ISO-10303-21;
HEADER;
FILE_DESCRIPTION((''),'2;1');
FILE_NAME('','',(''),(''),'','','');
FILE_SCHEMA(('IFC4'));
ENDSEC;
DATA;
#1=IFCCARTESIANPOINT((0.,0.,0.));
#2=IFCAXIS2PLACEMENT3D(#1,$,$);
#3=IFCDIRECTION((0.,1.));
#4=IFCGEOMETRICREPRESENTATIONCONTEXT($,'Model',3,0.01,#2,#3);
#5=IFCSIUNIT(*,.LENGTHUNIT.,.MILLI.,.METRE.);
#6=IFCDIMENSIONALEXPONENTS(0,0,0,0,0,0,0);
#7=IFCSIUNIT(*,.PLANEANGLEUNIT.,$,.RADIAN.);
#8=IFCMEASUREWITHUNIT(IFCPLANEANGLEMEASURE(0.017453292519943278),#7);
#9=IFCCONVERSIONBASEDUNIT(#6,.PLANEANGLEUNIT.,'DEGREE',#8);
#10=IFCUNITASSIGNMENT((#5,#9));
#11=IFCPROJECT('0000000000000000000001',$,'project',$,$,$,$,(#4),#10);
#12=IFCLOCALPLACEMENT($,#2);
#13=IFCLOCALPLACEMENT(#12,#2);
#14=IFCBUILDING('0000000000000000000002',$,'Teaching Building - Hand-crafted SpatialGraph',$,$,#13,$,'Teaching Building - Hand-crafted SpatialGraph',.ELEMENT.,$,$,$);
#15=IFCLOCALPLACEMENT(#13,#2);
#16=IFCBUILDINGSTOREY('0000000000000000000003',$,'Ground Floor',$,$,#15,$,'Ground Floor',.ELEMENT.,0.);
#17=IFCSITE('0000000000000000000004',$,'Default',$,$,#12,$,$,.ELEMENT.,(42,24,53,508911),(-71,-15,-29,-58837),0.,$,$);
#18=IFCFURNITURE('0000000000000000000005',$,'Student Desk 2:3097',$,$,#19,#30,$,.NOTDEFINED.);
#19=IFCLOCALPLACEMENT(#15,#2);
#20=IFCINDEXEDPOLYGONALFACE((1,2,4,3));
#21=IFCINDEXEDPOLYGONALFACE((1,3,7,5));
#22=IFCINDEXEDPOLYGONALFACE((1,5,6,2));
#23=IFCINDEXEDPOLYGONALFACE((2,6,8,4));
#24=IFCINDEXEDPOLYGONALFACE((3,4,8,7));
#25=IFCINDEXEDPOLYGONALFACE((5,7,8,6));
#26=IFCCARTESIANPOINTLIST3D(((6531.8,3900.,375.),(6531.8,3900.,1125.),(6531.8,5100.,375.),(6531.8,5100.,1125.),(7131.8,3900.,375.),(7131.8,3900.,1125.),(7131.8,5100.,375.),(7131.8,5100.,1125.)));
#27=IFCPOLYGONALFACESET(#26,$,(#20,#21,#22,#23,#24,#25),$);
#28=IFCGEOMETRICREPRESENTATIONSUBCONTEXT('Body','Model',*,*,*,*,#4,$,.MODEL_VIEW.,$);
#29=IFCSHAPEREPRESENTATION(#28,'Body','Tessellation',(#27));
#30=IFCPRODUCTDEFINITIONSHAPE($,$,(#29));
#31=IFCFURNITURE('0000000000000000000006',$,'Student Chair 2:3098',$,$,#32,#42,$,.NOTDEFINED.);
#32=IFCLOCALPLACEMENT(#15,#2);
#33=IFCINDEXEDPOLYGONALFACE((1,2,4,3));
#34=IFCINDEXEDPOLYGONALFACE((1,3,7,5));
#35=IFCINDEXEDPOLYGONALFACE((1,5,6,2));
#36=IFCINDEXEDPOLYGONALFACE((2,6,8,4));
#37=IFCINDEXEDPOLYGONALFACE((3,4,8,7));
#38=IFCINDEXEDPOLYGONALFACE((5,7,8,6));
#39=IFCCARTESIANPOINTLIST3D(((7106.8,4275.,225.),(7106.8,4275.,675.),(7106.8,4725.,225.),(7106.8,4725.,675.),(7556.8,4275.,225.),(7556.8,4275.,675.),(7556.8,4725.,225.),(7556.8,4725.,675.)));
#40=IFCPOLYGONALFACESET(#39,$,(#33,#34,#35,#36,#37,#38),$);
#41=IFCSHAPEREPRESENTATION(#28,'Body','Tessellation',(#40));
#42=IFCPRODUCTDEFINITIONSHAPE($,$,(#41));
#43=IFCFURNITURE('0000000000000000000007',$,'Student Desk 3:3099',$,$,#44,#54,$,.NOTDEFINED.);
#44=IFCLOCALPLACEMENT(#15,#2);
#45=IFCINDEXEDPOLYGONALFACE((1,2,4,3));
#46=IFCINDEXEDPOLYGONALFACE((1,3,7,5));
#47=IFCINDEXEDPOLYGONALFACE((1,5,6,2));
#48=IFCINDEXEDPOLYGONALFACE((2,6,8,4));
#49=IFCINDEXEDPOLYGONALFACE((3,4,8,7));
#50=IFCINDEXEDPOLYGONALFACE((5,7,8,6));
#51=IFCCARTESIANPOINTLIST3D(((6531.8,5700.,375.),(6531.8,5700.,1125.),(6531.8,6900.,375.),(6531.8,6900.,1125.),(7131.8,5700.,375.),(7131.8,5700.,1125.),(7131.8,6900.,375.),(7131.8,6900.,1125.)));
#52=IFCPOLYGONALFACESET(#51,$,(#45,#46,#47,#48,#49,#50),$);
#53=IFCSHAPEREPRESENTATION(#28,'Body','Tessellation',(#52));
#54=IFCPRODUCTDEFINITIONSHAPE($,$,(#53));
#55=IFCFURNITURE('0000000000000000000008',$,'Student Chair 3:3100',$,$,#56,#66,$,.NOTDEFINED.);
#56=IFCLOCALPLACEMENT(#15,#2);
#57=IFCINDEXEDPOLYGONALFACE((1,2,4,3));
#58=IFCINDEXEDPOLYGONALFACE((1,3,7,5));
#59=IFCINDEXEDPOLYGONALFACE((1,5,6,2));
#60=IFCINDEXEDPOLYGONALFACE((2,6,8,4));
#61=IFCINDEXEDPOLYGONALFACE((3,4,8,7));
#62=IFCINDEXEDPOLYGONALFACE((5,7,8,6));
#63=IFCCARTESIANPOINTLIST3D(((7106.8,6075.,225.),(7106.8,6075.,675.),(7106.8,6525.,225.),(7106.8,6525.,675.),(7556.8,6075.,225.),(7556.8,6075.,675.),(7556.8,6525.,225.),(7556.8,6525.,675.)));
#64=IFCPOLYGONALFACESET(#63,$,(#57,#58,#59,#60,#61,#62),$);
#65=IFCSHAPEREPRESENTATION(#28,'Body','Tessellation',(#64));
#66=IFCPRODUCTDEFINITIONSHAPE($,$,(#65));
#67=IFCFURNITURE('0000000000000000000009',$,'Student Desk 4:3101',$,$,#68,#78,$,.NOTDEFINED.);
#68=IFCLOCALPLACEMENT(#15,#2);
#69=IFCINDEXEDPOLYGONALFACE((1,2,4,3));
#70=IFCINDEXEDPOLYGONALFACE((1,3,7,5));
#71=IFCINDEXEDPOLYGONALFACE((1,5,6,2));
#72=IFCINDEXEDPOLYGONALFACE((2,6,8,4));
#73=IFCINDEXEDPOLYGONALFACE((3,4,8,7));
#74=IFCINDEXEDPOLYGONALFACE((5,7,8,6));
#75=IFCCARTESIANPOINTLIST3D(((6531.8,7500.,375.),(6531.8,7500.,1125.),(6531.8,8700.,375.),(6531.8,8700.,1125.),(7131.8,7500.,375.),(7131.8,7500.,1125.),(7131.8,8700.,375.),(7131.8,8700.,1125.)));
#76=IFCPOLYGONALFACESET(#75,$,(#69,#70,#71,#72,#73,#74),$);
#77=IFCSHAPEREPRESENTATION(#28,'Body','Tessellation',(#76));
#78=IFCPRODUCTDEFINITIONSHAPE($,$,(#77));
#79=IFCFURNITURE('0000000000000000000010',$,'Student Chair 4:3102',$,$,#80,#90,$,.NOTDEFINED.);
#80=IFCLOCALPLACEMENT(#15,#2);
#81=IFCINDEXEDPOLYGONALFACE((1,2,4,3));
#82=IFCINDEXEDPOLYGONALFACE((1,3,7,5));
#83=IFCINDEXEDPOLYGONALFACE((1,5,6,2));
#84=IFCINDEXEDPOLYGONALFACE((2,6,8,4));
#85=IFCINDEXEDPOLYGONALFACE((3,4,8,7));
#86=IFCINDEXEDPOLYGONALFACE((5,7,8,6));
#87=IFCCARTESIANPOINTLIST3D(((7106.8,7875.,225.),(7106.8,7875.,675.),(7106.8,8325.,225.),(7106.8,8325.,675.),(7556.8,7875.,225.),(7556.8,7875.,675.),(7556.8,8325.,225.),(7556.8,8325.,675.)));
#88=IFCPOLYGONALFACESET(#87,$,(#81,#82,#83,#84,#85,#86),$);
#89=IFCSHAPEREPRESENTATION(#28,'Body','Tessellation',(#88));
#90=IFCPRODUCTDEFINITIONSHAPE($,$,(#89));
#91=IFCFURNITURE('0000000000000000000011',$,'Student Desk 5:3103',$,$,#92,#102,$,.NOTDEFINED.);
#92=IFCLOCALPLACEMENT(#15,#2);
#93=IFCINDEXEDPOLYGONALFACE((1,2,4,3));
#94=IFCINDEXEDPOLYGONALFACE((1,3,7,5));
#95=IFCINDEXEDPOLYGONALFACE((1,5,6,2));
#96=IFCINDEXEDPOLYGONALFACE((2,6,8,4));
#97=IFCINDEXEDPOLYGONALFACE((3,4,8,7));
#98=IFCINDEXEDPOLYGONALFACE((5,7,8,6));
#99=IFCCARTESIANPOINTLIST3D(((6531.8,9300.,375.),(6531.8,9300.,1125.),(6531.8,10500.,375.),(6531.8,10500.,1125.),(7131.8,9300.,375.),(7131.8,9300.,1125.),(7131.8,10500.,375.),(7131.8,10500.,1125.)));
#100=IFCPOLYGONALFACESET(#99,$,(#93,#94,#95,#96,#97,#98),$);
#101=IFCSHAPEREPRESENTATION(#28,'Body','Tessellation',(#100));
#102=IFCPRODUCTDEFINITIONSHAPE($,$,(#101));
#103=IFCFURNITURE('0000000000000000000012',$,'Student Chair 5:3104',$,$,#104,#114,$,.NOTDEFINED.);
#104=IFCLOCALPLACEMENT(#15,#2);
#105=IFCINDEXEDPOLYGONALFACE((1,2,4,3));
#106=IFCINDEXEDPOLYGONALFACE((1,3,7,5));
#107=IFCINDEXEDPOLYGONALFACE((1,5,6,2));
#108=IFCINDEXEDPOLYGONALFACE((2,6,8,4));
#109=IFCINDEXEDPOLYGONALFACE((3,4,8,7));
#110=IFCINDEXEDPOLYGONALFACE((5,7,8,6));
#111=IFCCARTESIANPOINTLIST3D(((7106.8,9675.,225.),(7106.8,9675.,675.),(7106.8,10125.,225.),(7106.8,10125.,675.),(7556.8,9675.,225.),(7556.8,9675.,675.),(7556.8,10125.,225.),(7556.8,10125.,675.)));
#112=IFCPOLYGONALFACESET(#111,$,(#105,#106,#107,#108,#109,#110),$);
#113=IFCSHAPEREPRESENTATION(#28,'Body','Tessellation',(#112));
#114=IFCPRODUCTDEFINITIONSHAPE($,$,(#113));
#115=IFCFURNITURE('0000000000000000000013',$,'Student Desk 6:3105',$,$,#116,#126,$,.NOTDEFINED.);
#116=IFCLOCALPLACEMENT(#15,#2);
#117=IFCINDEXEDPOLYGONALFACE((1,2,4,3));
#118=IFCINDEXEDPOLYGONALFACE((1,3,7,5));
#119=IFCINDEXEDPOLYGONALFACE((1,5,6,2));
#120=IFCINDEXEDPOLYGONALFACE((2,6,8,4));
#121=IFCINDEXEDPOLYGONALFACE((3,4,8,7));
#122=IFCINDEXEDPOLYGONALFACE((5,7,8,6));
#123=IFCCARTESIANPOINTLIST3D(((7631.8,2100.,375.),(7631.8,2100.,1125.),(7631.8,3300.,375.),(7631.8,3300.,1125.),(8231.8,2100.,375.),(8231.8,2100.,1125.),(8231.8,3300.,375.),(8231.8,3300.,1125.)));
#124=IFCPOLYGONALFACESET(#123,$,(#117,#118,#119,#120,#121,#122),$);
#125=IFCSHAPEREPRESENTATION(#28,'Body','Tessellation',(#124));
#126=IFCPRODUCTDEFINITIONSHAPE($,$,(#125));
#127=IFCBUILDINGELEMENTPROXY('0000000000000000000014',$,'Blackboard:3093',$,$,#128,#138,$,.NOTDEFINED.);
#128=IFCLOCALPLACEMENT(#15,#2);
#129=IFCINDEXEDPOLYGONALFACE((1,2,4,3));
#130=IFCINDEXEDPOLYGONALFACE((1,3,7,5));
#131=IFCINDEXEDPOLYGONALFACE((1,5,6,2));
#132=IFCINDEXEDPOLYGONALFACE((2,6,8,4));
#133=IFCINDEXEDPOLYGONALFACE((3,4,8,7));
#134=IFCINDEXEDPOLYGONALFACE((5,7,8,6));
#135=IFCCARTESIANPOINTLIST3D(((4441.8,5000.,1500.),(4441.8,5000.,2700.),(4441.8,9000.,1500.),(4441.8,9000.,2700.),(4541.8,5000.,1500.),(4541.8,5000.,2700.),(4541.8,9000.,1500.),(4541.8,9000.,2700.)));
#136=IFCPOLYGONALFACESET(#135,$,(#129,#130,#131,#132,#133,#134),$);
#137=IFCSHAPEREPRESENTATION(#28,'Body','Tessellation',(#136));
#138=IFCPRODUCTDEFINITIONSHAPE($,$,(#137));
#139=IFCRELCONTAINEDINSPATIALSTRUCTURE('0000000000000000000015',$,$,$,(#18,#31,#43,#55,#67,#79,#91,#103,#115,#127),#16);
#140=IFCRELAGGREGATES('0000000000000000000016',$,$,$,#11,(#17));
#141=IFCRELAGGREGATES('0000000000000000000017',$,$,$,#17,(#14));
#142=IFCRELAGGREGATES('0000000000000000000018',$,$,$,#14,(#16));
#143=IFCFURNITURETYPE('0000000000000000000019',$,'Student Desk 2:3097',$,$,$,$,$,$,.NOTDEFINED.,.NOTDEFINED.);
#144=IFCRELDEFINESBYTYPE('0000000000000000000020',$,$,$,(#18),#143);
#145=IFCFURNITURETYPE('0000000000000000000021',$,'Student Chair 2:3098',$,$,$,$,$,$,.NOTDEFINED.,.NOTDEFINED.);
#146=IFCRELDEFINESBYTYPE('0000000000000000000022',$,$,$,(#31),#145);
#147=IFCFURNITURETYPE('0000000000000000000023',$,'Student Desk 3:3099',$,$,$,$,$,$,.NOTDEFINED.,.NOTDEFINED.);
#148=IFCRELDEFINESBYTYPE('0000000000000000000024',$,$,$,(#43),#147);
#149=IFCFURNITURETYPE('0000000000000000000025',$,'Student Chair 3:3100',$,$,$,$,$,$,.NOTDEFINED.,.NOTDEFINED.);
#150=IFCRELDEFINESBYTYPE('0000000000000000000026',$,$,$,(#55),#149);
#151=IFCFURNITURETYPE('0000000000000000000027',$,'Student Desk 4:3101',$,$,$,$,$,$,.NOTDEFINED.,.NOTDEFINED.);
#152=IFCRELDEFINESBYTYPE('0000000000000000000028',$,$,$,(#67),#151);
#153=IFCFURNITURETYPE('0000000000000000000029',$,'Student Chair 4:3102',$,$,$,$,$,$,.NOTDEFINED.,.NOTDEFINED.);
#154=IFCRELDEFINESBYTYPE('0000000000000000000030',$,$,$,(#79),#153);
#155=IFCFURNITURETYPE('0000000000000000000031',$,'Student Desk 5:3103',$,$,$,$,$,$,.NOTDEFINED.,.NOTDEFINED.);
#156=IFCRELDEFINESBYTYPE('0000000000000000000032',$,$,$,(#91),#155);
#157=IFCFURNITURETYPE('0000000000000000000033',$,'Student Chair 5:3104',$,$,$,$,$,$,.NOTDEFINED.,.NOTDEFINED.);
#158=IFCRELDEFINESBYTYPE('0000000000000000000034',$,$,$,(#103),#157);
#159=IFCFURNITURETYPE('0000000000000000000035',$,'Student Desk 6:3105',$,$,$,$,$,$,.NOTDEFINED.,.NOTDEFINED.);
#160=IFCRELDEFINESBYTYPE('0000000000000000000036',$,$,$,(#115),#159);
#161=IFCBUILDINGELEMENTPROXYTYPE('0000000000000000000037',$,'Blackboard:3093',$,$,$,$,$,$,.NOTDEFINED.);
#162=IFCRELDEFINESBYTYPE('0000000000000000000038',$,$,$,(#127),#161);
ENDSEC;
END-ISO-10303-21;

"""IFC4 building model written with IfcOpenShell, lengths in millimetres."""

from ifc_helpers import new_model, entity, si_unit, converted_unit, direction, frame, frame_2d, origin, origin_2d_with_axis, place, context, subcontext, project, spatial, rectangle, extrude, type_object, element, save


model = new_model("IFC4")

# Units and contexts
model_context = context("Model", 3, precision=0.01, world=origin(), true_north=direction((0.0, 1.0)))
body_context = subcontext(model_context, "Body", "Model", "MODEL_VIEW")
ifc_project = project(units=[si_unit("LENGTHUNIT", "METRE", prefix="MILLI"), converted_unit("PLANEANGLEUNIT", "DEGREE", entity("IfcPlaneAngleMeasure", 0.017453292519943278), si_unit("PLANEANGLEUNIT", "RADIAN"), dimensions=[0, 0, 0, 0, 0, 0, 0])], contexts=[model_context])

# Site, building, storey
site_placement = place(None, origin())
site = spatial("IfcSite", under=ifc_project, at=site_placement, Name="Default", CompositionType="ELEMENT", RefLatitude=(42, 24, 53, 508911), RefLongitude=(-71, -15, -29, -58837), RefElevation=0.0)
building_placement = place(site_placement, origin())
building = spatial("IfcBuilding", under=site, at=building_placement, Name="Teaching Building - Hand-crafted SpatialGraph", LongName="Teaching Building - Hand-crafted SpatialGraph", CompositionType="ELEMENT")
storey_placement = place(building_placement, origin())
storey = spatial("IfcBuildingStorey", under=building, at=storey_placement, Name="Ground Floor", LongName="Ground Floor", CompositionType="ELEMENT", Elevation=0.0)

# Furniture
furniture_type_1 = type_object("IfcFurnitureType", Name="Student Desk 2:3097", PredefinedType="NOTDEFINED")
furniture_1_placement = place(storey_placement, origin())
element("IfcFurniture", 1, at=furniture_1_placement, inside=storey, type_object=furniture_type_1, Name="Student Desk 2:3097", PredefinedType="NOTDEFINED", context=body_context, shape_type="SweptSolid", body=[
    extrude(rectangle(XDim=1200.0, YDim=600.0, at=frame_2d((0.0, 0.0), x_axis=(1.0, 0.0))), frame((6831.8, 4500.0, 375.0), z_axis=(0.0, 0.0, 1.0), x_axis=(0.0, 1.0, 0.0)), (0.0, 0.0, 1.0), 750.0),
])
furniture_type_2 = type_object("IfcFurnitureType", Name="Student Chair 2:3098", PredefinedType="NOTDEFINED")
furniture_2_placement = place(storey_placement, origin())
element("IfcFurniture", 2, at=furniture_2_placement, inside=storey, type_object=furniture_type_2, Name="Student Chair 2:3098", PredefinedType="NOTDEFINED", context=body_context, shape_type="SweptSolid", body=[
    extrude(rectangle(XDim=450.0, YDim=450.0, at=frame_2d((0.0, 0.0), x_axis=(1.0, 0.0))), frame((7331.8, 4500.0, 225.0)), (0.0, 0.0, 1.0), 450.0),
])
furniture_type_3 = type_object("IfcFurnitureType", Name="Student Desk 3:3099", PredefinedType="NOTDEFINED")
furniture_3_placement = place(storey_placement, origin())
element("IfcFurniture", 3, at=furniture_3_placement, inside=storey, type_object=furniture_type_3, Name="Student Desk 3:3099", PredefinedType="NOTDEFINED", context=body_context, shape_type="SweptSolid", body=[
    extrude(rectangle(XDim=1200.0, YDim=600.0, at=origin_2d_with_axis()), frame((6831.8, 6300.0, 375.0), z_axis=(0.0, 0.0, 1.0), x_axis=(0.0, 1.0, 0.0)), (0.0, 0.0, 1.0), 750.0),
])
furniture_type_4 = type_object("IfcFurnitureType", Name="Student Chair 3:3100", PredefinedType="NOTDEFINED")
furniture_4_placement = place(storey_placement, origin())
element("IfcFurniture", 4, at=furniture_4_placement, inside=storey, type_object=furniture_type_4, Name="Student Chair 3:3100", PredefinedType="NOTDEFINED", context=body_context, shape_type="SweptSolid", body=[
    extrude(rectangle(XDim=450.0, YDim=450.0, at=frame_2d((0.0, 0.0), x_axis=(1.0, 0.0))), frame((7331.8, 6300.0, 225.0)), (0.0, 0.0, 1.0), 450.0),
])
furniture_type_5 = type_object("IfcFurnitureType", Name="Student Desk 4:3101", PredefinedType="NOTDEFINED")
furniture_5_placement = place(storey_placement, origin())
element("IfcFurniture", 5, at=furniture_5_placement, inside=storey, type_object=furniture_type_5, Name="Student Desk 4:3101", PredefinedType="NOTDEFINED", context=body_context, shape_type="SweptSolid", body=[
    extrude(rectangle(XDim=1200.0, YDim=600.0, at=origin_2d_with_axis()), frame((6831.8, 8100.0, 375.0), z_axis=(0.0, 0.0, 1.0), x_axis=(0.0, 1.0, 0.0)), (0.0, 0.0, 1.0), 750.0),
])
furniture_type_6 = type_object("IfcFurnitureType", Name="Student Chair 4:3102", PredefinedType="NOTDEFINED")
furniture_6_placement = place(storey_placement, origin())
element("IfcFurniture", 6, at=furniture_6_placement, inside=storey, type_object=furniture_type_6, Name="Student Chair 4:3102", PredefinedType="NOTDEFINED", context=body_context, shape_type="SweptSolid", body=[
    extrude(rectangle(XDim=450.0, YDim=450.0, at=frame_2d((0.0, 0.0), x_axis=(1.0, 0.0))), frame((7331.8, 8100.0, 225.0)), (0.0, 0.0, 1.0), 450.0),
])
furniture_type_7 = type_object("IfcFurnitureType", Name="Student Desk 5:3103", PredefinedType="NOTDEFINED")
furniture_7_placement = place(storey_placement, origin())
element("IfcFurniture", 7, at=furniture_7_placement, inside=storey, type_object=furniture_type_7, Name="Student Desk 5:3103", PredefinedType="NOTDEFINED", context=body_context, shape_type="SweptSolid", body=[
    extrude(rectangle(XDim=1200.0, YDim=600.0, at=origin_2d_with_axis()), frame((6831.8, 9900.0, 375.0), z_axis=(0.0, 0.0, 1.0), x_axis=(0.0, 1.0, 0.0)), (0.0, 0.0, 1.0), 750.0),
])
furniture_type_8 = type_object("IfcFurnitureType", Name="Student Chair 5:3104", PredefinedType="NOTDEFINED")
furniture_8_placement = place(storey_placement, origin())
element("IfcFurniture", 8, at=furniture_8_placement, inside=storey, type_object=furniture_type_8, Name="Student Chair 5:3104", PredefinedType="NOTDEFINED", context=body_context, shape_type="SweptSolid", body=[
    extrude(rectangle(XDim=450.0, YDim=450.0, at=frame_2d((0.0, 0.0), x_axis=(1.0, 0.0))), frame((7331.8, 9900.0, 225.0)), (0.0, 0.0, 1.0), 450.0),
])
furniture_type_9 = type_object("IfcFurnitureType", Name="Student Desk 6:3105", PredefinedType="NOTDEFINED")
furniture_9_placement = place(storey_placement, origin())
element("IfcFurniture", 9, at=furniture_9_placement, inside=storey, type_object=furniture_type_9, Name="Student Desk 6:3105", PredefinedType="NOTDEFINED", context=body_context, shape_type="SweptSolid", body=[
    extrude(rectangle(XDim=1200.0, YDim=600.0, at=origin_2d_with_axis()), frame((7931.8, 2700.0, 375.0), z_axis=(0.0, 0.0, 1.0), x_axis=(0.0, 1.0, 0.0)), (0.0, 0.0, 1.0), 750.0),
])

# Building element proxy
building_element_proxy_type = type_object("IfcBuildingElementProxyType", Name="Blackboard:3093", PredefinedType="NOTDEFINED")
proxy_placement = place(storey_placement, origin())
element("IfcBuildingElementProxy", 10, at=proxy_placement, inside=storey, type_object=building_element_proxy_type, Name="Blackboard:3093", PredefinedType="NOTDEFINED", context=body_context, shape_type="SweptSolid", body=[
    extrude(rectangle(XDim=100.0, YDim=4000.0, at=origin_2d_with_axis()), frame((4491.8, 7000.0, 1500.0)), (0.0, 0.0, 1.0), 1200.0),
])

save(model, "model.ifc")
